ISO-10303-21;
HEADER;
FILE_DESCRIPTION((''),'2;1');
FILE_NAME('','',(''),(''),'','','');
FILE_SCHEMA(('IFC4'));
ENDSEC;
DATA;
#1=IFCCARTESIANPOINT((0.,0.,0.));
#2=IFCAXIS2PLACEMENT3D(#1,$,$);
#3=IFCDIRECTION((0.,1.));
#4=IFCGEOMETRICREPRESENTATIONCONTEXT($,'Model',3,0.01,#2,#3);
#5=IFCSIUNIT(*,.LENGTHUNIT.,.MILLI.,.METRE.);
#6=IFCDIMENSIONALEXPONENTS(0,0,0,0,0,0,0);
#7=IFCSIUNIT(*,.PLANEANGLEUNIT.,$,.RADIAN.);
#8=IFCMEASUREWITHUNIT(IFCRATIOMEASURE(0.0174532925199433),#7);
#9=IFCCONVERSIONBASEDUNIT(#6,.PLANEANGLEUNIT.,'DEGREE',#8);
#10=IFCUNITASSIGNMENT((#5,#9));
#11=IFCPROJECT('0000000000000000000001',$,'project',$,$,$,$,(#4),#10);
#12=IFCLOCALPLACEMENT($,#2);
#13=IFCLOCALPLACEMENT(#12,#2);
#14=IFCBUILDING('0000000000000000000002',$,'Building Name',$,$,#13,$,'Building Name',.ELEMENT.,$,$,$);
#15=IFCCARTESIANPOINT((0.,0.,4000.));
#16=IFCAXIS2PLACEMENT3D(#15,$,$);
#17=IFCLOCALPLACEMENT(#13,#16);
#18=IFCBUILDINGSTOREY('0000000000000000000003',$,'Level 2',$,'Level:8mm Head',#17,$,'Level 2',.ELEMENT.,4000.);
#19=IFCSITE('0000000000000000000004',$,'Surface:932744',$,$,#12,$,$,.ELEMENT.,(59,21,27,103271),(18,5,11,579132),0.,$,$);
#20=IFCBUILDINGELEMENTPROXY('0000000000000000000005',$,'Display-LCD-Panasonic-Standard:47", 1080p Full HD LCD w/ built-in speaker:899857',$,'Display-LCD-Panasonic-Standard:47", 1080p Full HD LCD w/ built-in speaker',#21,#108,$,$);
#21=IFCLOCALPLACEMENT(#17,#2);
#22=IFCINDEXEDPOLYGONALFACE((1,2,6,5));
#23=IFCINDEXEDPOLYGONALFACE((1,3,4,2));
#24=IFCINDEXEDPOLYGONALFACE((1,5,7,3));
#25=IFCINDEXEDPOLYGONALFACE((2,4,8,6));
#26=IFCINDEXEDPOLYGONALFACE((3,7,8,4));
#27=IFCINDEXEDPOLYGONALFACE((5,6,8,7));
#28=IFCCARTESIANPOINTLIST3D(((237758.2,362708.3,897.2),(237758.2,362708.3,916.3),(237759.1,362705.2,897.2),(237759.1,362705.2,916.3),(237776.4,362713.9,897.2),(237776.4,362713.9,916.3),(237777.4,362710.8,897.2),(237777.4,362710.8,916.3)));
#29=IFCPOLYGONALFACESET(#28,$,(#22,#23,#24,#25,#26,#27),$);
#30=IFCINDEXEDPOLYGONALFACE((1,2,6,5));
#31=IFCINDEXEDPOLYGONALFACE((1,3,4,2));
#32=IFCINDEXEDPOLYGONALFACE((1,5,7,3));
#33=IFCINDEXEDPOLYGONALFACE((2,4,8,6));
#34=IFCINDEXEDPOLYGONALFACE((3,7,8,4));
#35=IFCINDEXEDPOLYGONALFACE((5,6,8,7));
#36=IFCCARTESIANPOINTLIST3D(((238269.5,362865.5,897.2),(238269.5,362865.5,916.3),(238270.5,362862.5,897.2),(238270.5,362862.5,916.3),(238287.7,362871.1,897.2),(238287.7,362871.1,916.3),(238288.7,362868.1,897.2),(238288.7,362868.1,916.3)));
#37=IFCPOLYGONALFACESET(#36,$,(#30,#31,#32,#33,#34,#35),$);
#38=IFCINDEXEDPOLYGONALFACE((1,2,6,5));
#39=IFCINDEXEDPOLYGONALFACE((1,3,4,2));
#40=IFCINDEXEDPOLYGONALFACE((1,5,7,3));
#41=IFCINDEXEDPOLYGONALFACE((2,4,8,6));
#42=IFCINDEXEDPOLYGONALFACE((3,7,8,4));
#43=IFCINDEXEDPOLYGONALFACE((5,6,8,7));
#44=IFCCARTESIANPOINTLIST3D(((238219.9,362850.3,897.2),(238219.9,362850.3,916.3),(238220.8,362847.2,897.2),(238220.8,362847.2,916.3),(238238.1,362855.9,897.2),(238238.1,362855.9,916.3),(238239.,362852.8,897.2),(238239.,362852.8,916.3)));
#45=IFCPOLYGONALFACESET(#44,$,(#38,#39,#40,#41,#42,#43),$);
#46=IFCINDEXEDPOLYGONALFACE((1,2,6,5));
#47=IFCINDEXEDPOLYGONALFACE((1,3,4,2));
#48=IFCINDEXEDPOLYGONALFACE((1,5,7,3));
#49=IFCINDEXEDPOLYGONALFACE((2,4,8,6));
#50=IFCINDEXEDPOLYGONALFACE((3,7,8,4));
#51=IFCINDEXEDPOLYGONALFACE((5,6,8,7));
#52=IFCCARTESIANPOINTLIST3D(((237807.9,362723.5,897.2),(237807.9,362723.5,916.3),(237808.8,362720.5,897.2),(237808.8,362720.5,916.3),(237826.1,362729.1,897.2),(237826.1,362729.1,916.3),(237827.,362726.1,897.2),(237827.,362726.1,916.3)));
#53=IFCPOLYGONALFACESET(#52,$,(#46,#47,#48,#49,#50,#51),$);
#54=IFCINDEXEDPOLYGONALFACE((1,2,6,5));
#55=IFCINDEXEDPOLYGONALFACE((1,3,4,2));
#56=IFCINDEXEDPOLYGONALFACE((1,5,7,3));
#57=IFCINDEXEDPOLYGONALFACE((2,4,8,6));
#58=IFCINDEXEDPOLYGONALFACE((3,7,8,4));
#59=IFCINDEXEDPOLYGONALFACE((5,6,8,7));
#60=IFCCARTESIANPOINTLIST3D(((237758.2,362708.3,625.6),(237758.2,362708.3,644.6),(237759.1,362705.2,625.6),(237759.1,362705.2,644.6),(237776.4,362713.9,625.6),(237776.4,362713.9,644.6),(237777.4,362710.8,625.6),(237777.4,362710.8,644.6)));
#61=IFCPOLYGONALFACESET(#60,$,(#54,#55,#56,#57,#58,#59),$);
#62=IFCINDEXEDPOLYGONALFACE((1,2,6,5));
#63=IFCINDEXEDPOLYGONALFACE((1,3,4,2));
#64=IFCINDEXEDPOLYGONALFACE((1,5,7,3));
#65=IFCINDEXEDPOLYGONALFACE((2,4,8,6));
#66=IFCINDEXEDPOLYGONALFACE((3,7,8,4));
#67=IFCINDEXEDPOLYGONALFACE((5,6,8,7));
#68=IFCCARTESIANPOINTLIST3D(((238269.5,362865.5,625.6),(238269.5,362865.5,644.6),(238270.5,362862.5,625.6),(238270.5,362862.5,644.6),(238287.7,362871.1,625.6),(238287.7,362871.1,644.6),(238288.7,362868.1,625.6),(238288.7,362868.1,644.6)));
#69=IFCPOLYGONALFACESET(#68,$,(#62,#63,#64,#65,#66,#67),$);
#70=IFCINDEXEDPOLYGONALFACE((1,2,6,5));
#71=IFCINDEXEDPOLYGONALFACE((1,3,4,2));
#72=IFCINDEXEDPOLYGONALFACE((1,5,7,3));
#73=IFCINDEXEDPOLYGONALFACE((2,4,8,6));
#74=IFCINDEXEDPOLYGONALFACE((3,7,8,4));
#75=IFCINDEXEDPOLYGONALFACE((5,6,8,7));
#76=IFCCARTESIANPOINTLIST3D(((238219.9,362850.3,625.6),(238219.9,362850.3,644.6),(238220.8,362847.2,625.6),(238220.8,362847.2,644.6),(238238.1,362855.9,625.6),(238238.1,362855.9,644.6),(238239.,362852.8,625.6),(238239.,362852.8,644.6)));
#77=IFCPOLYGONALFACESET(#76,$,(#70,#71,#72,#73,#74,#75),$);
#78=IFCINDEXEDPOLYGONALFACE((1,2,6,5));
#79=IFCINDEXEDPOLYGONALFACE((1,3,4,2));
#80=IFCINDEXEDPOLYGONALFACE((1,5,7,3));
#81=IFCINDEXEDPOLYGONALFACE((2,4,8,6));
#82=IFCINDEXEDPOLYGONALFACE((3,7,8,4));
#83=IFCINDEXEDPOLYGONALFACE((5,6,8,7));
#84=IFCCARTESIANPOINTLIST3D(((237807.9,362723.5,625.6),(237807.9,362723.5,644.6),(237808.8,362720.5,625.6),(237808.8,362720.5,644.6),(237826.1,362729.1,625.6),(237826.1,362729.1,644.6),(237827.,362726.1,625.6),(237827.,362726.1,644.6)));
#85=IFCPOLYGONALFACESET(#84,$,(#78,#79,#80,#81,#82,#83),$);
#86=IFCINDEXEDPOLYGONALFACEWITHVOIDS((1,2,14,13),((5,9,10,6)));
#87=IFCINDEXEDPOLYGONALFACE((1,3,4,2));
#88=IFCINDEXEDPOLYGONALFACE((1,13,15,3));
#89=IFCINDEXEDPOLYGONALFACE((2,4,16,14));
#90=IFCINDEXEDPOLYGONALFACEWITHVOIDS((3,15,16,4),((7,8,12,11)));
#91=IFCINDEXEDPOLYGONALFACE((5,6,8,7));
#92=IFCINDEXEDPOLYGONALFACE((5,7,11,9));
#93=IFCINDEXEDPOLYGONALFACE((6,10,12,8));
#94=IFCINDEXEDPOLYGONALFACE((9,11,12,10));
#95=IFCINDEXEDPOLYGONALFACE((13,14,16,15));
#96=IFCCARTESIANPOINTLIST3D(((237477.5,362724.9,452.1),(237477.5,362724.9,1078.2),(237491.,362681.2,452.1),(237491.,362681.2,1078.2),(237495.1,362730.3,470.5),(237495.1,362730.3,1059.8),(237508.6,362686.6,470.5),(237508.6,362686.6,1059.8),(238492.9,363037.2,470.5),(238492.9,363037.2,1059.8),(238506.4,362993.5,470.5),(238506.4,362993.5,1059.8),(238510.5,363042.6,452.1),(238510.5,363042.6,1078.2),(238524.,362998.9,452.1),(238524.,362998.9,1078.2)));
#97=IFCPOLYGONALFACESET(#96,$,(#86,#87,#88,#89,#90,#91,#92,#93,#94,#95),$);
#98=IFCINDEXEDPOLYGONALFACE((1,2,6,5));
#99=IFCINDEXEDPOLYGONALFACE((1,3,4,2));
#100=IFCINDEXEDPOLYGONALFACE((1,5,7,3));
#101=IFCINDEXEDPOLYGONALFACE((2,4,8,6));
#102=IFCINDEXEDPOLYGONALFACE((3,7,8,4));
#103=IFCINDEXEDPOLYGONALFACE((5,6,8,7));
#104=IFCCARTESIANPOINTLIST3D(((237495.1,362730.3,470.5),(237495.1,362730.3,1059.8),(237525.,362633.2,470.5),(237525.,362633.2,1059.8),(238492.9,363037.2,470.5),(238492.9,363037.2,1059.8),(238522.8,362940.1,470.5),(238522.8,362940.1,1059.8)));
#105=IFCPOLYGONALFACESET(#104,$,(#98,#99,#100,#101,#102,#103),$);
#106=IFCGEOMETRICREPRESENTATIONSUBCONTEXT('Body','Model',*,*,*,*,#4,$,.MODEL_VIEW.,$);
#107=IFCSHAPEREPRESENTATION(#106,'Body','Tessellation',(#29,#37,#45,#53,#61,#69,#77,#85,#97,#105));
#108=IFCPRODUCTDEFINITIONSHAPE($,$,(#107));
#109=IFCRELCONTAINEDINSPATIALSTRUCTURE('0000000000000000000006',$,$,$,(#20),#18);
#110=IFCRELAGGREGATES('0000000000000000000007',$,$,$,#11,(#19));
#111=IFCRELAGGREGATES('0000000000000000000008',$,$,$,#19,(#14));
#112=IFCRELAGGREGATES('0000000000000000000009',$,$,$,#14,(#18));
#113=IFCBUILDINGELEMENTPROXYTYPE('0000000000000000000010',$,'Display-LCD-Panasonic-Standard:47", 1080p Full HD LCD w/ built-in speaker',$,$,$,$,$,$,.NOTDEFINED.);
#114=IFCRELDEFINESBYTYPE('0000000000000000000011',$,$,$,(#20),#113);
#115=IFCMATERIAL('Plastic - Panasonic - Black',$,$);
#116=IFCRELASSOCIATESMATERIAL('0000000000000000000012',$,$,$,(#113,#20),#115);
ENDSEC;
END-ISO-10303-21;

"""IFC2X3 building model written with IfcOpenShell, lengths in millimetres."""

from ifc_helpers import new_model, entity, si_unit, converted_unit, direction, frame, frame_2d, origin, origin_2d_with_axis, place, context, subcontext, project, spatial, polyline, rectangle, outline, extrude, source, transform, mapped, material, type_object, type_shapes, element, save


model = new_model("IFC2X3")

# Units and contexts
model_context = context("Model", 3, precision=0.01, world=origin(), true_north=direction((0.0, 1.0)))
body_context = subcontext(model_context, "Body", "Model", "MODEL_VIEW")
ifc_project = project(units=[si_unit("LENGTHUNIT", "METRE", prefix="MILLI"), converted_unit("PLANEANGLEUNIT", "DEGREE", entity("IfcRatioMeasure", 0.0174532925199433), si_unit("PLANEANGLEUNIT", "RADIAN"), dimensions=[0, 0, 0, 0, 0, 0, 0])], contexts=[model_context])

# Site, building, storey
site_placement = place(None, origin())
site = spatial("IfcSite", under=ifc_project, at=site_placement, Name="Surface:932744", CompositionType="ELEMENT", RefLatitude=(59, 21, 27, 103271), RefLongitude=(18, 5, 11, 579132), RefElevation=0.0)
building_placement = place(site_placement, origin())
building = spatial("IfcBuilding", under=site, at=building_placement, Name="Building Name", LongName="Building Name", CompositionType="ELEMENT")
storey_placement = place(building_placement, frame((0.0, 0.0, 4000.0)))
storey = spatial("IfcBuildingStorey", under=building, at=storey_placement, Name="Level 2", ObjectType="Level:8mm Head", LongName="Level 2", CompositionType="ELEMENT", Elevation=4000.0)

# Building element proxy
ifc_material = material(Name="Plastic - Panasonic - Black")
building_element_proxy_type = type_object("IfcBuildingElementProxyType", Name="Display-LCD-Panasonic-Standard:47\", 1080p Full HD LCD w/ built-in speaker", PredefinedType="NOTDEFINED", material=ifc_material)
shared_shape = source(origin(), body_context, "Body", "SweptSolid", [
    extrude(rectangle(XDim=19.0, YDim=19.1, at=origin_2d_with_axis()), frame((267.5, 187.5, 0.0), z_axis=(0.0, 0.0, 1.0), x_axis=(0.0, 1.0, 0.0)), (0.0, 0.0, 1.0), 3.2),
    extrude(rectangle(XDim=19.0, YDim=19.1, at=origin_2d_with_axis()), frame((-267.5, 187.5, 0.0), z_axis=(0.0, 0.0, 1.0), x_axis=(0.0, 1.0, 0.0)), (0.0, 0.0, 1.0), 3.2),
    extrude(rectangle(XDim=19.0, YDim=19.0, at=origin_2d_with_axis()), frame((-215.5, 187.5, 0.0), z_axis=(0.0, 0.0, 1.0), x_axis=(0.0, 1.0, 0.0)), (0.0, 0.0, 1.0), 3.2),
    extrude(rectangle(XDim=19.0, YDim=19.0, at=frame_2d((0.0, 0.0), x_axis=(1.0, 0.0))), frame((215.5, 187.5, 0.0), z_axis=(0.0, 0.0, 1.0), x_axis=(0.0, 1.0, 0.0)), (0.0, 0.0, 1.0), 3.2),
    extrude(rectangle(XDim=19.0, YDim=19.1, at=frame_2d((0.0, 0.0), x_axis=(1.0, 0.0))), frame((267.5, -84.1, 0.0), z_axis=(0.0, 0.0, 1.0), x_axis=(0.0, 1.0, 0.0)), (0.0, 0.0, 1.0), 3.2),
    extrude(rectangle(XDim=19.0, YDim=19.1, at=frame_2d((0.0, 0.0), x_axis=(1.0, 0.0))), frame((-267.5, -84.1, 0.0), z_axis=(0.0, 0.0, 1.0), x_axis=(0.0, 1.0, 0.0)), (0.0, 0.0, 1.0), 3.2),
    extrude(rectangle(XDim=19.0, YDim=19.0, at=frame_2d((0.0, 0.0), x_axis=(1.0, 0.0))), frame((-215.5, -84.1, 0.0), z_axis=(0.0, 0.0, 1.0), x_axis=(0.0, 1.0, 0.0)), (0.0, 0.0, 1.0), 3.2),
    extrude(rectangle(XDim=19.0, YDim=19.0, at=frame_2d((0.0, 0.0), x_axis=(1.0, 0.0))), frame((215.5, -84.1, 0.0), z_axis=(0.0, 0.0, 1.0), x_axis=(0.0, 1.0, 0.0)), (0.0, 0.0, 1.0), 3.2),
    extrude(outline(polyline([(-313.1, -540.4), (313.1, -540.4), (313.1, 540.4), (-313.1, 540.4), (-313.1, -540.4)]), holes=[polyline([(294.6, -522.0), (-294.6, -522.0), (-294.6, 522.0), (294.6, 522.0), (294.6, -522.0)])]), frame((0.0, 46.0, 55.9), z_axis=(0.0, 0.0, 1.0), x_axis=(0.0, 1.0, 0.0)), (0.0, 0.0, 1.0), 45.7),
    extrude(rectangle(XDim=1043.9, YDim=589.3, at=frame_2d((0.0, 0.0), x_axis=(1.0, 0.0))), frame((0.0, 46.0, 0.0), z_axis=(0.0, 0.0, 1.0), x_axis=(-1.0, 0.0, 0.0)), (0.0, 0.0, 1.0), 101.6),
])
type_shapes(building_element_proxy_type, [shared_shape])
for number, where, z_axis, x_axis, name in (
    (1, (238023.9, 362786.7, 719.2), (-0.29398, 0.955811, 0.0), (-0.955811, -0.29398, 0.0), "Display-LCD-Panasonic-Standard:47\", 1080p Full HD LCD w/ built-in speaker:899857"),
):
    element("IfcBuildingElementProxy", number, at=place(storey_placement, frame(where, z_axis=z_axis, x_axis=x_axis)), inside=storey, type_object=building_element_proxy_type, material=ifc_material, Name=name, ObjectType="Display-LCD-Panasonic-Standard:47\", 1080p Full HD LCD w/ built-in speaker", context=body_context, shape_type="MappedRepresentation", body=[
        mapped(shared_shape, transform((0.0, 0.0, 0.0), scale=1.0)),
    ])

save(model, "model.ifc")
